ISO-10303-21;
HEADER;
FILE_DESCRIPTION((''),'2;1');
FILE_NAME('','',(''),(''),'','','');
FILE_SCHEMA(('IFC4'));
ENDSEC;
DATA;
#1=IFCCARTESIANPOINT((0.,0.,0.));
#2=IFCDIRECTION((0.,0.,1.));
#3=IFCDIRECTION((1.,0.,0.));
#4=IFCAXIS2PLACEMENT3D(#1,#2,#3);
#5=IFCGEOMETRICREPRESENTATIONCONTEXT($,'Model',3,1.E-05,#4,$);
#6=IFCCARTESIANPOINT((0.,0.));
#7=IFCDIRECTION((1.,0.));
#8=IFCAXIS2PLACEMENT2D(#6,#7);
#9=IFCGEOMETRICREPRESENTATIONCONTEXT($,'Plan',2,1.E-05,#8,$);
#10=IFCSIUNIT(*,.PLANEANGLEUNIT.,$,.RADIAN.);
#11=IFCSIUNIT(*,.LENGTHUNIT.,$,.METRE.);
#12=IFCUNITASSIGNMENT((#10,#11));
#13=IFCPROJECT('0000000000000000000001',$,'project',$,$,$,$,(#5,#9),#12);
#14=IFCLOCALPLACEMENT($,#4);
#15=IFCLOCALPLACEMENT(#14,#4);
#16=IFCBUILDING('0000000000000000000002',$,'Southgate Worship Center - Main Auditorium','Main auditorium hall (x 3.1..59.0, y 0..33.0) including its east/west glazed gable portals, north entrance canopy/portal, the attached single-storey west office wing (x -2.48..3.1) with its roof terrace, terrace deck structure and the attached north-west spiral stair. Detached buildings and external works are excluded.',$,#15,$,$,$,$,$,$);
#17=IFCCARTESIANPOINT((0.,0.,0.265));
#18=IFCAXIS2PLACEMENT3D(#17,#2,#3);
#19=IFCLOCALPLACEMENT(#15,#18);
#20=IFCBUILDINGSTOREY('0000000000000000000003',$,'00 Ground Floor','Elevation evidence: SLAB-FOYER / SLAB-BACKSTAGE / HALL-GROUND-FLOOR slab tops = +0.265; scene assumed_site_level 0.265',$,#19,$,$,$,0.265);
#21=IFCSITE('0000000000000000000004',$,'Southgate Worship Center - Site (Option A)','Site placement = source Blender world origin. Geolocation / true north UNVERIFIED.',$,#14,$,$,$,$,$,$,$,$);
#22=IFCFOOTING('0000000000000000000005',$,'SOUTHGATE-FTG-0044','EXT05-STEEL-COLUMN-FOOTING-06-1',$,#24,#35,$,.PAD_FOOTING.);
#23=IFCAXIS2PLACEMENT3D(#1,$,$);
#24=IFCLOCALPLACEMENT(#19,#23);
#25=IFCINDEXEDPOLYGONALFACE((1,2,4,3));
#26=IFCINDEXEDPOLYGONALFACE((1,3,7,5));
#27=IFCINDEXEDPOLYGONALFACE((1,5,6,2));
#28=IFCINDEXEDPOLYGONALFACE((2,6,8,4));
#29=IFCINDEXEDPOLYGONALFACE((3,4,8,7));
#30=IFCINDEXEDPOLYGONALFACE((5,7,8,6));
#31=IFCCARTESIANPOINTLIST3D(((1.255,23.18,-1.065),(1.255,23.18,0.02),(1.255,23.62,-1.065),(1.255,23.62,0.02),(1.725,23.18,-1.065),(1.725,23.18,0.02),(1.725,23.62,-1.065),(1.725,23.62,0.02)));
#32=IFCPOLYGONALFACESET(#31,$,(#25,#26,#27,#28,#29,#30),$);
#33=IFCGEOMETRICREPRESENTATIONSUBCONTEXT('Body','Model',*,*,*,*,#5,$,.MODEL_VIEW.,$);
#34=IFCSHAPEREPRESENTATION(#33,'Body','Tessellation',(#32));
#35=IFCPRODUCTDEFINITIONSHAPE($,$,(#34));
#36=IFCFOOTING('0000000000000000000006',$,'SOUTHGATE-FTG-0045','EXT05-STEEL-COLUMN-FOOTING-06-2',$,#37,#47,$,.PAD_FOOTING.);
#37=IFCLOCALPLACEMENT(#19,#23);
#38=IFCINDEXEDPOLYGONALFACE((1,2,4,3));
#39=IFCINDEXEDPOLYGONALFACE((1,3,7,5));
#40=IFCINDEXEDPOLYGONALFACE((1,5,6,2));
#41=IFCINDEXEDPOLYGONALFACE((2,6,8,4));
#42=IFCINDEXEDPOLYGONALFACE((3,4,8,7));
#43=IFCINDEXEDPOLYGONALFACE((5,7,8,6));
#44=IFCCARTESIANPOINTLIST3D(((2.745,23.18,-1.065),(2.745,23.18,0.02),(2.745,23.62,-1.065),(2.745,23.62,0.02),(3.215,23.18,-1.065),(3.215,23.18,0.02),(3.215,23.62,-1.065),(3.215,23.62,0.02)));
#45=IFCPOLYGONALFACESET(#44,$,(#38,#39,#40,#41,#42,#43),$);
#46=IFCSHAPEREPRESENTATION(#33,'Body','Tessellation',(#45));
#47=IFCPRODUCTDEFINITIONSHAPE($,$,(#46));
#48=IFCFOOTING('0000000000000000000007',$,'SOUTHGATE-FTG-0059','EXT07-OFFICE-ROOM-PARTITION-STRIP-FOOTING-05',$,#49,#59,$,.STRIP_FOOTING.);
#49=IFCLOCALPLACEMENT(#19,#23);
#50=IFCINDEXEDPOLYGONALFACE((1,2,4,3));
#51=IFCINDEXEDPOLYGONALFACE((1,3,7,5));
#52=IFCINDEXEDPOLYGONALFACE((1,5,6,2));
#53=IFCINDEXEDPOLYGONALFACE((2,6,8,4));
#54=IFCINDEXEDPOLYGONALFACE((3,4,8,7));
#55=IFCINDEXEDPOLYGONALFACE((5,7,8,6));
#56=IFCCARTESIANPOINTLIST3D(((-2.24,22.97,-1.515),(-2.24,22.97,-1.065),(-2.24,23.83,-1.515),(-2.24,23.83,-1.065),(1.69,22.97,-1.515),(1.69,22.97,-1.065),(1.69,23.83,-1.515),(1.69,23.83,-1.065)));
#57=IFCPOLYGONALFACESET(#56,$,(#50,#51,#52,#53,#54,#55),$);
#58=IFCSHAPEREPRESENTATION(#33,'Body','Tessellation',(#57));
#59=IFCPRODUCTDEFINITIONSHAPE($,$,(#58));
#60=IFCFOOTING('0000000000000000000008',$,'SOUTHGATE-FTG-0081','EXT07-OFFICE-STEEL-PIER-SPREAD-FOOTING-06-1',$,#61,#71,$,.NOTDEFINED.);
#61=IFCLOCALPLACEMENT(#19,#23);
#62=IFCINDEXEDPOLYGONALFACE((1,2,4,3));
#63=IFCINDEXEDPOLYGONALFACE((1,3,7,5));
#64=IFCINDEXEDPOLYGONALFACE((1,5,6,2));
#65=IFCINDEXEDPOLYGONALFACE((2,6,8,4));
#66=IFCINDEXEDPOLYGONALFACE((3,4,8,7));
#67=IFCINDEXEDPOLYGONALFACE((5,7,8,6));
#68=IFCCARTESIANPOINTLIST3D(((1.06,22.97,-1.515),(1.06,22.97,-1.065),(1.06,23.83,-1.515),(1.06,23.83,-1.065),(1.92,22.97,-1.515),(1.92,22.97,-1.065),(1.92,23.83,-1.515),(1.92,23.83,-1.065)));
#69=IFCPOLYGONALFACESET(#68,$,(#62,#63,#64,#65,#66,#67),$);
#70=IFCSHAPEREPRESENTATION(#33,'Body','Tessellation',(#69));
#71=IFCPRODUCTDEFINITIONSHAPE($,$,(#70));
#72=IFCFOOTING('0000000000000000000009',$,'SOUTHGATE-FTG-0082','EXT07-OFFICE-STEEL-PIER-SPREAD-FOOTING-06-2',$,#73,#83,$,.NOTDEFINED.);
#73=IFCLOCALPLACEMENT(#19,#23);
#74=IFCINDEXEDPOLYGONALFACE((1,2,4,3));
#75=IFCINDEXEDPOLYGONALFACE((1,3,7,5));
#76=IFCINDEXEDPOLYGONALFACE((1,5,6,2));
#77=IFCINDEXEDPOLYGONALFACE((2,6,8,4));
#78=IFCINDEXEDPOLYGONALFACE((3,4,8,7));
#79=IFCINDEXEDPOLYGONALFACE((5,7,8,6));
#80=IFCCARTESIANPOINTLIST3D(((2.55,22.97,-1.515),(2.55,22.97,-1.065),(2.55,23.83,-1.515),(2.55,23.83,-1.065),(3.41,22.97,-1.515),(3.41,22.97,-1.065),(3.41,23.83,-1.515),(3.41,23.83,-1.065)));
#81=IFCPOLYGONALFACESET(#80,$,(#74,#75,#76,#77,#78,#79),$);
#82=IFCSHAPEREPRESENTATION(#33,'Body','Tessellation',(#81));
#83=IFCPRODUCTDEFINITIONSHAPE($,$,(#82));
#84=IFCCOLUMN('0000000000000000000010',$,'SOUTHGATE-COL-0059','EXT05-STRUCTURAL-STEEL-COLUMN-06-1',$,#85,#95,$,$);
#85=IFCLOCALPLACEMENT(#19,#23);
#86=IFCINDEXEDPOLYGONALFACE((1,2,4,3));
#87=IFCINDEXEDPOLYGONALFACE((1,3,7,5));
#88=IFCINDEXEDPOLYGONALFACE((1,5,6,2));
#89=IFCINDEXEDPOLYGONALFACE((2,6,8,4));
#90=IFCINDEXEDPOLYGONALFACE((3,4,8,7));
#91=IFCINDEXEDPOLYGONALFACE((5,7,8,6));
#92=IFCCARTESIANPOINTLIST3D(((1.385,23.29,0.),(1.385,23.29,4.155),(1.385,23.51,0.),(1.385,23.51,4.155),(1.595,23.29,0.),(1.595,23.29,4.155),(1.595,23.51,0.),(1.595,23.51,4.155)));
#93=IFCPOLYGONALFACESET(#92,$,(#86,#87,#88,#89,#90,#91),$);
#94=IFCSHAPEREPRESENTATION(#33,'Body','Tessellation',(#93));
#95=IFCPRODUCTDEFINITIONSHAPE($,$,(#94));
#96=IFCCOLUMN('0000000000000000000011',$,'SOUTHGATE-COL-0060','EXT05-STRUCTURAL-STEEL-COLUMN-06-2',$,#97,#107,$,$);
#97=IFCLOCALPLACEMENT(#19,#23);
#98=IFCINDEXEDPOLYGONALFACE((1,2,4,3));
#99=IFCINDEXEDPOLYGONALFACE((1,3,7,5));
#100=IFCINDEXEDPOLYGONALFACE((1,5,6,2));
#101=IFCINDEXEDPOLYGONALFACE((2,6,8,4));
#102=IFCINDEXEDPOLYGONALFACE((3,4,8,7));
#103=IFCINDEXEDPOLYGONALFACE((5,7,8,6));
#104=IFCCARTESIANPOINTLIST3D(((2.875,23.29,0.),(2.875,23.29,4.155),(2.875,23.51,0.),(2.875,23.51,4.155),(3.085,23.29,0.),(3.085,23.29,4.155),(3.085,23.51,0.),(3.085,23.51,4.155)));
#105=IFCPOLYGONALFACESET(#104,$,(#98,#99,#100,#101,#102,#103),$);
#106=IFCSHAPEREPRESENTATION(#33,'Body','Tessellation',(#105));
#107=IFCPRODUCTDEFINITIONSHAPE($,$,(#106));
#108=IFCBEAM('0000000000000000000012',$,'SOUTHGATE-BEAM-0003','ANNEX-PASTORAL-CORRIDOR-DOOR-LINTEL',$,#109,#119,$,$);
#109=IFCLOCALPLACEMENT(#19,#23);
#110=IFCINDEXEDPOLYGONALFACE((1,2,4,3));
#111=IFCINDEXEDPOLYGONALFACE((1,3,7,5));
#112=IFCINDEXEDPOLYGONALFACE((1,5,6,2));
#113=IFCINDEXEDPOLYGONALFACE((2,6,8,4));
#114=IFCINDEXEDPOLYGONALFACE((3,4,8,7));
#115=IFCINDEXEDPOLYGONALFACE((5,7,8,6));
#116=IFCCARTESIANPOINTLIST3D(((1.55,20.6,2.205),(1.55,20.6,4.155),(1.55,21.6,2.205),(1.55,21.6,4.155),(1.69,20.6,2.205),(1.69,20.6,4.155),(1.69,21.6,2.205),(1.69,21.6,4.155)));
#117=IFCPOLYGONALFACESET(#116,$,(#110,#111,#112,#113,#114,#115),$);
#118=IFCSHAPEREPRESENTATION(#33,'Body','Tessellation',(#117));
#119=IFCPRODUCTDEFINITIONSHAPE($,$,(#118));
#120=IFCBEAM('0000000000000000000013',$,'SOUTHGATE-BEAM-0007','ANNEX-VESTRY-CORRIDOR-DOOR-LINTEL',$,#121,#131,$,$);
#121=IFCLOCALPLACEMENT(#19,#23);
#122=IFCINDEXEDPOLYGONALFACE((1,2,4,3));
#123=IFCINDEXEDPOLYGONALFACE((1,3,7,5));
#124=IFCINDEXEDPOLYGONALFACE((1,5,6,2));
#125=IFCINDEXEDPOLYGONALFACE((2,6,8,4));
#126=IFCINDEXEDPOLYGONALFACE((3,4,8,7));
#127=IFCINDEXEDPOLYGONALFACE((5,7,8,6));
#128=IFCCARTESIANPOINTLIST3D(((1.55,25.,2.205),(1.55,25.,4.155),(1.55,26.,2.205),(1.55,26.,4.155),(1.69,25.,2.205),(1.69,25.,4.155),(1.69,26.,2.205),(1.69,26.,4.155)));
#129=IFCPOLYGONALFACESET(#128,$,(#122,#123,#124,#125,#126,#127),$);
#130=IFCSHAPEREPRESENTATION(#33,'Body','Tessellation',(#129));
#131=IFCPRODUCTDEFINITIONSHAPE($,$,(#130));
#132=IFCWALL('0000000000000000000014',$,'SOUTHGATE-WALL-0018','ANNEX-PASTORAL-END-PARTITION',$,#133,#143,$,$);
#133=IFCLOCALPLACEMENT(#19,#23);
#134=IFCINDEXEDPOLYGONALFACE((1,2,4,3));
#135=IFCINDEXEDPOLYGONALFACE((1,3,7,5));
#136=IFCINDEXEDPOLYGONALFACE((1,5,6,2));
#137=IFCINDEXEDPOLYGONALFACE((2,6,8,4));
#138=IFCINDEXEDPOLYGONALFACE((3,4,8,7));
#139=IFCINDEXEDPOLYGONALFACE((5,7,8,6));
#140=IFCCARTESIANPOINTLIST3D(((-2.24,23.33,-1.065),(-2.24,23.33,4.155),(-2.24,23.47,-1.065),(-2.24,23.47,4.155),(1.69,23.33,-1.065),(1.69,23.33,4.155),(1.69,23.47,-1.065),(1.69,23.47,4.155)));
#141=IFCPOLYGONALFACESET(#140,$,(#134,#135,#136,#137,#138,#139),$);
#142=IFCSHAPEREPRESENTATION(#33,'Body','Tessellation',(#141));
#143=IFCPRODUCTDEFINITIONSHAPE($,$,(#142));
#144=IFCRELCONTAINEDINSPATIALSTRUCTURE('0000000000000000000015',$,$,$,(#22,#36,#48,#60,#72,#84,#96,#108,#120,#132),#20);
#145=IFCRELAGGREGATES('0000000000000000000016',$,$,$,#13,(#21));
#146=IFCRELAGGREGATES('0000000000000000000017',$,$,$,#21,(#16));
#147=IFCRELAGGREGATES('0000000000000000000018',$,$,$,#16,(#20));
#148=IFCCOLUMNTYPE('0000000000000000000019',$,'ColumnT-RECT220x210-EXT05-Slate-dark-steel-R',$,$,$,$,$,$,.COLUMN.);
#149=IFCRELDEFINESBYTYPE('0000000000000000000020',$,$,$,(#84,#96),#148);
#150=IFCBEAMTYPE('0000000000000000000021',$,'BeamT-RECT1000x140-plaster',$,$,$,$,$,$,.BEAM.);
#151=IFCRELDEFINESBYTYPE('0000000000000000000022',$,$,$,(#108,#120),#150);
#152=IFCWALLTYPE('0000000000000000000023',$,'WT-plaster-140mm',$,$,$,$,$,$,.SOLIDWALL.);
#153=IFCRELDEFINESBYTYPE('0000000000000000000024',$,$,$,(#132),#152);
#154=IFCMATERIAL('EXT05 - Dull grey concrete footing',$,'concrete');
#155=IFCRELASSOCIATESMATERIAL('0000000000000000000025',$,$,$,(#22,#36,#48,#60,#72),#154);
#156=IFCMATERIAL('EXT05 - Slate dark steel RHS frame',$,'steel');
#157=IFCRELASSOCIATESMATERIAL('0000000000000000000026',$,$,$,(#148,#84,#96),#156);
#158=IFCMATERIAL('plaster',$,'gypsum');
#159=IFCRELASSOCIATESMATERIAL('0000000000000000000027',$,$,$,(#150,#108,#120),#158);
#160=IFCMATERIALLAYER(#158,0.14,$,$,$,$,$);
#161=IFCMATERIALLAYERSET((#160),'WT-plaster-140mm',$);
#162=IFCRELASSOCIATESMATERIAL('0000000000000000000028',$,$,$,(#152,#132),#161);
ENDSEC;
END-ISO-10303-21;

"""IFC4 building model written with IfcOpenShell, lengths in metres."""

from ifc_helpers import new_model, si_unit, frame, origin_with_axes, origin_2d, origin_2d_with_axis, place, context, subcontext, project, spatial, indexed_curve, rectangle, outline, extrude, material, layer, layer_set, layer_usage, material_profile, profile_set, profile_usage, type_object, element, save


model = new_model("IFC4")

# Units and contexts
model_context = context("Model", 3, precision=1e-05, world=origin_with_axes())
plan_context = context("Plan", 2, precision=1e-05, world=origin_2d_with_axis())
body_context = subcontext(model_context, "Body", "Model", "MODEL_VIEW")
ifc_project = project(units=[si_unit("PLANEANGLEUNIT", "RADIAN"), si_unit("LENGTHUNIT", "METRE")], contexts=[model_context, plan_context])

# Site, building, storey
site_placement = place(None, origin_with_axes())
site = spatial("IfcSite", under=ifc_project, at=site_placement, Name="Southgate Worship Center - Site (Option A)", Description="Site placement = source Blender world origin. Geolocation / true north UNVERIFIED.")
building_placement = place(site_placement, origin_with_axes())
building = spatial("IfcBuilding", under=site, at=building_placement, Name="Southgate Worship Center - Main Auditorium", Description="Main auditorium hall (x 3.1..59.0, y 0..33.0) including its east/west glazed gable portals, north entrance canopy/portal, the attached single-storey west office wing (x -2.48..3.1) with its roof terrace, terrace deck structure and the attached north-west spiral stair. Detached buildings and external works are excluded.")
storey_placement = place(building_placement, frame((0.0, 0.0, 0.265), z_axis=(0.0, 0.0, 1.0), x_axis=(1.0, 0.0, 0.0)))
storey = spatial("IfcBuildingStorey", under=building, at=storey_placement, Name="00 Ground Floor", Description="Elevation evidence: SLAB-FOYER / SLAB-BACKSTAGE / HALL-GROUND-FLOOR slab tops = +0.265; scene assumed_site_level 0.265", Elevation=0.265)

# Footings
ifc_material_1 = material(Name="EXT05 - Dull grey concrete footing", Category="concrete")
footing_1_placement = place(storey_placement, frame((1.255, 23.18, -1.065), z_axis=(0.0, 0.0, 1.0), x_axis=(1.0, 0.0, 0.0)))
element("IfcFooting", 1, at=footing_1_placement, inside=storey, material=ifc_material_1, Name="SOUTHGATE-FTG-0044", Description="EXT05-STEEL-COLUMN-FOOTING-06-1", PredefinedType="PAD_FOOTING", context=body_context, shape_type="SweptSolid", body=[
    extrude(rectangle(XDim=0.44, YDim=0.47, at=origin_2d()), frame((0.235, 0.22, 0.0), z_axis=(0.0, 0.0, 1.0), x_axis=(0.0, 1.0, 0.0)), (0.0, 0.0, 1.0), 1.085),
])
footing_2_placement = place(storey_placement, frame((2.745, 23.18, -1.065), z_axis=(0.0, 0.0, 1.0), x_axis=(1.0, 0.0, 0.0)))
element("IfcFooting", 2, at=footing_2_placement, inside=storey, material=ifc_material_1, Name="SOUTHGATE-FTG-0045", Description="EXT05-STEEL-COLUMN-FOOTING-06-2", PredefinedType="PAD_FOOTING", context=body_context, shape_type="SweptSolid", body=[
    extrude(rectangle(XDim=0.44, YDim=0.47, at=origin_2d()), frame((0.235, 0.22, 0.0), z_axis=(0.0, 0.0, 1.0), x_axis=(0.0, 1.0, 0.0)), (0.0, 0.0, 1.0), 1.085),
])
footing_3_placement = place(storey_placement, frame((-2.24, 22.97, -1.515), z_axis=(0.0, 0.0, 1.0), x_axis=(1.0, 0.0, 0.0)))
element("IfcFooting", 3, at=footing_3_placement, inside=storey, material=ifc_material_1, Name="SOUTHGATE-FTG-0059", Description="EXT07-OFFICE-ROOM-PARTITION-STRIP-FOOTING-05", PredefinedType="STRIP_FOOTING", context=body_context, shape_type="SweptSolid", body=[
    extrude(rectangle(XDim=0.86, YDim=3.93, at=origin_2d()), frame((1.965, 0.43, 0.0), z_axis=(0.0, 0.0, 1.0), x_axis=(0.0, -1.0, 0.0)), (0.0, 0.0, 1.0), 0.45),
])
footing_4_placement = place(storey_placement, frame((1.06, 22.97, -1.515), z_axis=(0.0, 0.0, 1.0), x_axis=(1.0, 0.0, 0.0)))
element("IfcFooting", 4, at=footing_4_placement, inside=storey, material=ifc_material_1, Name="SOUTHGATE-FTG-0081", Description="EXT07-OFFICE-STEEL-PIER-SPREAD-FOOTING-06-1", PredefinedType="NOTDEFINED", context=body_context, shape_type="SweptSolid", body=[
    extrude(rectangle(XDim=0.86, YDim=0.86, at=origin_2d()), frame((0.43, 0.43, 0.0), z_axis=(0.0, 0.0, 1.0), x_axis=(0.0, -1.0, 0.0)), (0.0, 0.0, 1.0), 0.45),
])
footing_5_placement = place(storey_placement, frame((2.55, 22.97, -1.515), z_axis=(0.0, 0.0, 1.0), x_axis=(1.0, 0.0, 0.0)))
element("IfcFooting", 5, at=footing_5_placement, inside=storey, material=ifc_material_1, Name="SOUTHGATE-FTG-0082", Description="EXT07-OFFICE-STEEL-PIER-SPREAD-FOOTING-06-2", PredefinedType="NOTDEFINED", context=body_context, shape_type="SweptSolid", body=[
    extrude(rectangle(XDim=0.86, YDim=0.86, at=origin_2d()), frame((0.43, 0.43, 0.0), z_axis=(0.0, 0.0, 1.0), x_axis=(0.0, -1.0, 0.0)), (0.0, 0.0, 1.0), 0.45),
])

# Columns
ifc_material_2 = material(Name="EXT05 - Slate dark steel RHS frame", Category="steel")
ifc_material_profile_1 = material_profile(ifc_material_2, rectangle(XDim=0.22, YDim=0.21, at=origin_2d()))
ifc_profile_set_1 = profile_set([ifc_material_profile_1], Name="ColumnT-RECT220x210-EXT05-Slate-dark-steel-R")
ifc_profile_usage_1 = profile_usage(ifc_profile_set_1)
column_type = type_object("IfcColumnType", Name="ColumnT-RECT220x210-EXT05-Slate-dark-steel-R", PredefinedType="COLUMN", material=ifc_profile_set_1)
for number, where, z_axis, x_axis, name, description in (
    (6, (1.49, 23.4, 0.0), (0.0, 0.0, 1.0), (0.0, 1.0, 0.0), "SOUTHGATE-COL-0059", "EXT05-STRUCTURAL-STEEL-COLUMN-06-1"),
    (7, (2.98, 23.4, 0.0), (0.0, 0.0, 1.0), (0.0, 1.0, 0.0), "SOUTHGATE-COL-0060", "EXT05-STRUCTURAL-STEEL-COLUMN-06-2"),
):
    element("IfcColumn", number, at=place(storey_placement, frame(where, z_axis=z_axis, x_axis=x_axis)), inside=storey, type_object=column_type, material=ifc_profile_usage_1, Name=name, Description=description, context=body_context, shape_type="SweptSolid", body=[
        extrude(rectangle(XDim=0.22, YDim=0.21, at=origin_2d()), origin_with_axes(), (0.0, 0.0, 1.0), 4.155),
    ])

# Beams
ifc_material_3 = material(Name="plaster", Category="gypsum")
ifc_material_profile_2 = material_profile(ifc_material_3, rectangle(XDim=1.0, YDim=0.14, at=origin_2d()))
ifc_profile_set_2 = profile_set([ifc_material_profile_2], Name="BeamT-RECT1000x140-plaster")
ifc_profile_usage_2 = profile_usage(ifc_profile_set_2)
beam_type = type_object("IfcBeamType", Name="BeamT-RECT1000x140-plaster", PredefinedType="BEAM", material=ifc_profile_set_2)
for number, where, z_axis, x_axis, name, description in (
    (8, (1.62, 21.1, 2.205), (0.0, 0.0, 1.0), (0.0, 1.0, 0.0), "SOUTHGATE-BEAM-0003", "ANNEX-PASTORAL-CORRIDOR-DOOR-LINTEL"),
    (9, (1.62, 25.5, 2.205), (0.0, 0.0, 1.0), (0.0, 1.0, 0.0), "SOUTHGATE-BEAM-0007", "ANNEX-VESTRY-CORRIDOR-DOOR-LINTEL"),
):
    element("IfcBeam", number, at=place(storey_placement, frame(where, z_axis=z_axis, x_axis=x_axis)), inside=storey, type_object=beam_type, material=ifc_profile_usage_2, Name=name, Description=description, context=body_context, shape_type="SweptSolid", body=[
        extrude(rectangle(XDim=1.0, YDim=0.14, at=origin_2d()), origin_with_axes(), (0.0, 0.0, 1.0), 1.95),
    ])

# Wall
ifc_layer_1 = layer(ifc_material_3, 0.14)
ifc_layer_set_1 = layer_set([ifc_layer_1], Name="WT-plaster-140mm")
ifc_layer_usage_1 = layer_usage(ifc_layer_set_1, "AXIS2", "POSITIVE", 0.0)
wall_type_1 = type_object("IfcWallType", Name="WT-plaster-140mm", PredefinedType="SOLIDWALL", material=ifc_layer_set_1)
wall_1_placement = place(storey_placement, frame((1.69, 23.47, -1.065), z_axis=(0.0, 0.0, 1.0), x_axis=(-1.0, 0.0, 0.0)))
element("IfcWall", 10, at=wall_1_placement, inside=storey, type_object=wall_type_1, material=ifc_layer_usage_1, Name="SOUTHGATE-WALL-0018", Description="ANNEX-PASTORAL-END-PARTITION", context=body_context, shape_type="SweptSolid", body=[
    extrude(outline(indexed_curve([(0.0, 0.0), (0.0, 0.14), (3.93, 0.14), (3.93, 0.0), (0.0, 0.0)], self_intersect=False)), origin_with_axes(), (0.0, 0.0, 1.0), 5.22),
])

save(model, "model.ifc")
